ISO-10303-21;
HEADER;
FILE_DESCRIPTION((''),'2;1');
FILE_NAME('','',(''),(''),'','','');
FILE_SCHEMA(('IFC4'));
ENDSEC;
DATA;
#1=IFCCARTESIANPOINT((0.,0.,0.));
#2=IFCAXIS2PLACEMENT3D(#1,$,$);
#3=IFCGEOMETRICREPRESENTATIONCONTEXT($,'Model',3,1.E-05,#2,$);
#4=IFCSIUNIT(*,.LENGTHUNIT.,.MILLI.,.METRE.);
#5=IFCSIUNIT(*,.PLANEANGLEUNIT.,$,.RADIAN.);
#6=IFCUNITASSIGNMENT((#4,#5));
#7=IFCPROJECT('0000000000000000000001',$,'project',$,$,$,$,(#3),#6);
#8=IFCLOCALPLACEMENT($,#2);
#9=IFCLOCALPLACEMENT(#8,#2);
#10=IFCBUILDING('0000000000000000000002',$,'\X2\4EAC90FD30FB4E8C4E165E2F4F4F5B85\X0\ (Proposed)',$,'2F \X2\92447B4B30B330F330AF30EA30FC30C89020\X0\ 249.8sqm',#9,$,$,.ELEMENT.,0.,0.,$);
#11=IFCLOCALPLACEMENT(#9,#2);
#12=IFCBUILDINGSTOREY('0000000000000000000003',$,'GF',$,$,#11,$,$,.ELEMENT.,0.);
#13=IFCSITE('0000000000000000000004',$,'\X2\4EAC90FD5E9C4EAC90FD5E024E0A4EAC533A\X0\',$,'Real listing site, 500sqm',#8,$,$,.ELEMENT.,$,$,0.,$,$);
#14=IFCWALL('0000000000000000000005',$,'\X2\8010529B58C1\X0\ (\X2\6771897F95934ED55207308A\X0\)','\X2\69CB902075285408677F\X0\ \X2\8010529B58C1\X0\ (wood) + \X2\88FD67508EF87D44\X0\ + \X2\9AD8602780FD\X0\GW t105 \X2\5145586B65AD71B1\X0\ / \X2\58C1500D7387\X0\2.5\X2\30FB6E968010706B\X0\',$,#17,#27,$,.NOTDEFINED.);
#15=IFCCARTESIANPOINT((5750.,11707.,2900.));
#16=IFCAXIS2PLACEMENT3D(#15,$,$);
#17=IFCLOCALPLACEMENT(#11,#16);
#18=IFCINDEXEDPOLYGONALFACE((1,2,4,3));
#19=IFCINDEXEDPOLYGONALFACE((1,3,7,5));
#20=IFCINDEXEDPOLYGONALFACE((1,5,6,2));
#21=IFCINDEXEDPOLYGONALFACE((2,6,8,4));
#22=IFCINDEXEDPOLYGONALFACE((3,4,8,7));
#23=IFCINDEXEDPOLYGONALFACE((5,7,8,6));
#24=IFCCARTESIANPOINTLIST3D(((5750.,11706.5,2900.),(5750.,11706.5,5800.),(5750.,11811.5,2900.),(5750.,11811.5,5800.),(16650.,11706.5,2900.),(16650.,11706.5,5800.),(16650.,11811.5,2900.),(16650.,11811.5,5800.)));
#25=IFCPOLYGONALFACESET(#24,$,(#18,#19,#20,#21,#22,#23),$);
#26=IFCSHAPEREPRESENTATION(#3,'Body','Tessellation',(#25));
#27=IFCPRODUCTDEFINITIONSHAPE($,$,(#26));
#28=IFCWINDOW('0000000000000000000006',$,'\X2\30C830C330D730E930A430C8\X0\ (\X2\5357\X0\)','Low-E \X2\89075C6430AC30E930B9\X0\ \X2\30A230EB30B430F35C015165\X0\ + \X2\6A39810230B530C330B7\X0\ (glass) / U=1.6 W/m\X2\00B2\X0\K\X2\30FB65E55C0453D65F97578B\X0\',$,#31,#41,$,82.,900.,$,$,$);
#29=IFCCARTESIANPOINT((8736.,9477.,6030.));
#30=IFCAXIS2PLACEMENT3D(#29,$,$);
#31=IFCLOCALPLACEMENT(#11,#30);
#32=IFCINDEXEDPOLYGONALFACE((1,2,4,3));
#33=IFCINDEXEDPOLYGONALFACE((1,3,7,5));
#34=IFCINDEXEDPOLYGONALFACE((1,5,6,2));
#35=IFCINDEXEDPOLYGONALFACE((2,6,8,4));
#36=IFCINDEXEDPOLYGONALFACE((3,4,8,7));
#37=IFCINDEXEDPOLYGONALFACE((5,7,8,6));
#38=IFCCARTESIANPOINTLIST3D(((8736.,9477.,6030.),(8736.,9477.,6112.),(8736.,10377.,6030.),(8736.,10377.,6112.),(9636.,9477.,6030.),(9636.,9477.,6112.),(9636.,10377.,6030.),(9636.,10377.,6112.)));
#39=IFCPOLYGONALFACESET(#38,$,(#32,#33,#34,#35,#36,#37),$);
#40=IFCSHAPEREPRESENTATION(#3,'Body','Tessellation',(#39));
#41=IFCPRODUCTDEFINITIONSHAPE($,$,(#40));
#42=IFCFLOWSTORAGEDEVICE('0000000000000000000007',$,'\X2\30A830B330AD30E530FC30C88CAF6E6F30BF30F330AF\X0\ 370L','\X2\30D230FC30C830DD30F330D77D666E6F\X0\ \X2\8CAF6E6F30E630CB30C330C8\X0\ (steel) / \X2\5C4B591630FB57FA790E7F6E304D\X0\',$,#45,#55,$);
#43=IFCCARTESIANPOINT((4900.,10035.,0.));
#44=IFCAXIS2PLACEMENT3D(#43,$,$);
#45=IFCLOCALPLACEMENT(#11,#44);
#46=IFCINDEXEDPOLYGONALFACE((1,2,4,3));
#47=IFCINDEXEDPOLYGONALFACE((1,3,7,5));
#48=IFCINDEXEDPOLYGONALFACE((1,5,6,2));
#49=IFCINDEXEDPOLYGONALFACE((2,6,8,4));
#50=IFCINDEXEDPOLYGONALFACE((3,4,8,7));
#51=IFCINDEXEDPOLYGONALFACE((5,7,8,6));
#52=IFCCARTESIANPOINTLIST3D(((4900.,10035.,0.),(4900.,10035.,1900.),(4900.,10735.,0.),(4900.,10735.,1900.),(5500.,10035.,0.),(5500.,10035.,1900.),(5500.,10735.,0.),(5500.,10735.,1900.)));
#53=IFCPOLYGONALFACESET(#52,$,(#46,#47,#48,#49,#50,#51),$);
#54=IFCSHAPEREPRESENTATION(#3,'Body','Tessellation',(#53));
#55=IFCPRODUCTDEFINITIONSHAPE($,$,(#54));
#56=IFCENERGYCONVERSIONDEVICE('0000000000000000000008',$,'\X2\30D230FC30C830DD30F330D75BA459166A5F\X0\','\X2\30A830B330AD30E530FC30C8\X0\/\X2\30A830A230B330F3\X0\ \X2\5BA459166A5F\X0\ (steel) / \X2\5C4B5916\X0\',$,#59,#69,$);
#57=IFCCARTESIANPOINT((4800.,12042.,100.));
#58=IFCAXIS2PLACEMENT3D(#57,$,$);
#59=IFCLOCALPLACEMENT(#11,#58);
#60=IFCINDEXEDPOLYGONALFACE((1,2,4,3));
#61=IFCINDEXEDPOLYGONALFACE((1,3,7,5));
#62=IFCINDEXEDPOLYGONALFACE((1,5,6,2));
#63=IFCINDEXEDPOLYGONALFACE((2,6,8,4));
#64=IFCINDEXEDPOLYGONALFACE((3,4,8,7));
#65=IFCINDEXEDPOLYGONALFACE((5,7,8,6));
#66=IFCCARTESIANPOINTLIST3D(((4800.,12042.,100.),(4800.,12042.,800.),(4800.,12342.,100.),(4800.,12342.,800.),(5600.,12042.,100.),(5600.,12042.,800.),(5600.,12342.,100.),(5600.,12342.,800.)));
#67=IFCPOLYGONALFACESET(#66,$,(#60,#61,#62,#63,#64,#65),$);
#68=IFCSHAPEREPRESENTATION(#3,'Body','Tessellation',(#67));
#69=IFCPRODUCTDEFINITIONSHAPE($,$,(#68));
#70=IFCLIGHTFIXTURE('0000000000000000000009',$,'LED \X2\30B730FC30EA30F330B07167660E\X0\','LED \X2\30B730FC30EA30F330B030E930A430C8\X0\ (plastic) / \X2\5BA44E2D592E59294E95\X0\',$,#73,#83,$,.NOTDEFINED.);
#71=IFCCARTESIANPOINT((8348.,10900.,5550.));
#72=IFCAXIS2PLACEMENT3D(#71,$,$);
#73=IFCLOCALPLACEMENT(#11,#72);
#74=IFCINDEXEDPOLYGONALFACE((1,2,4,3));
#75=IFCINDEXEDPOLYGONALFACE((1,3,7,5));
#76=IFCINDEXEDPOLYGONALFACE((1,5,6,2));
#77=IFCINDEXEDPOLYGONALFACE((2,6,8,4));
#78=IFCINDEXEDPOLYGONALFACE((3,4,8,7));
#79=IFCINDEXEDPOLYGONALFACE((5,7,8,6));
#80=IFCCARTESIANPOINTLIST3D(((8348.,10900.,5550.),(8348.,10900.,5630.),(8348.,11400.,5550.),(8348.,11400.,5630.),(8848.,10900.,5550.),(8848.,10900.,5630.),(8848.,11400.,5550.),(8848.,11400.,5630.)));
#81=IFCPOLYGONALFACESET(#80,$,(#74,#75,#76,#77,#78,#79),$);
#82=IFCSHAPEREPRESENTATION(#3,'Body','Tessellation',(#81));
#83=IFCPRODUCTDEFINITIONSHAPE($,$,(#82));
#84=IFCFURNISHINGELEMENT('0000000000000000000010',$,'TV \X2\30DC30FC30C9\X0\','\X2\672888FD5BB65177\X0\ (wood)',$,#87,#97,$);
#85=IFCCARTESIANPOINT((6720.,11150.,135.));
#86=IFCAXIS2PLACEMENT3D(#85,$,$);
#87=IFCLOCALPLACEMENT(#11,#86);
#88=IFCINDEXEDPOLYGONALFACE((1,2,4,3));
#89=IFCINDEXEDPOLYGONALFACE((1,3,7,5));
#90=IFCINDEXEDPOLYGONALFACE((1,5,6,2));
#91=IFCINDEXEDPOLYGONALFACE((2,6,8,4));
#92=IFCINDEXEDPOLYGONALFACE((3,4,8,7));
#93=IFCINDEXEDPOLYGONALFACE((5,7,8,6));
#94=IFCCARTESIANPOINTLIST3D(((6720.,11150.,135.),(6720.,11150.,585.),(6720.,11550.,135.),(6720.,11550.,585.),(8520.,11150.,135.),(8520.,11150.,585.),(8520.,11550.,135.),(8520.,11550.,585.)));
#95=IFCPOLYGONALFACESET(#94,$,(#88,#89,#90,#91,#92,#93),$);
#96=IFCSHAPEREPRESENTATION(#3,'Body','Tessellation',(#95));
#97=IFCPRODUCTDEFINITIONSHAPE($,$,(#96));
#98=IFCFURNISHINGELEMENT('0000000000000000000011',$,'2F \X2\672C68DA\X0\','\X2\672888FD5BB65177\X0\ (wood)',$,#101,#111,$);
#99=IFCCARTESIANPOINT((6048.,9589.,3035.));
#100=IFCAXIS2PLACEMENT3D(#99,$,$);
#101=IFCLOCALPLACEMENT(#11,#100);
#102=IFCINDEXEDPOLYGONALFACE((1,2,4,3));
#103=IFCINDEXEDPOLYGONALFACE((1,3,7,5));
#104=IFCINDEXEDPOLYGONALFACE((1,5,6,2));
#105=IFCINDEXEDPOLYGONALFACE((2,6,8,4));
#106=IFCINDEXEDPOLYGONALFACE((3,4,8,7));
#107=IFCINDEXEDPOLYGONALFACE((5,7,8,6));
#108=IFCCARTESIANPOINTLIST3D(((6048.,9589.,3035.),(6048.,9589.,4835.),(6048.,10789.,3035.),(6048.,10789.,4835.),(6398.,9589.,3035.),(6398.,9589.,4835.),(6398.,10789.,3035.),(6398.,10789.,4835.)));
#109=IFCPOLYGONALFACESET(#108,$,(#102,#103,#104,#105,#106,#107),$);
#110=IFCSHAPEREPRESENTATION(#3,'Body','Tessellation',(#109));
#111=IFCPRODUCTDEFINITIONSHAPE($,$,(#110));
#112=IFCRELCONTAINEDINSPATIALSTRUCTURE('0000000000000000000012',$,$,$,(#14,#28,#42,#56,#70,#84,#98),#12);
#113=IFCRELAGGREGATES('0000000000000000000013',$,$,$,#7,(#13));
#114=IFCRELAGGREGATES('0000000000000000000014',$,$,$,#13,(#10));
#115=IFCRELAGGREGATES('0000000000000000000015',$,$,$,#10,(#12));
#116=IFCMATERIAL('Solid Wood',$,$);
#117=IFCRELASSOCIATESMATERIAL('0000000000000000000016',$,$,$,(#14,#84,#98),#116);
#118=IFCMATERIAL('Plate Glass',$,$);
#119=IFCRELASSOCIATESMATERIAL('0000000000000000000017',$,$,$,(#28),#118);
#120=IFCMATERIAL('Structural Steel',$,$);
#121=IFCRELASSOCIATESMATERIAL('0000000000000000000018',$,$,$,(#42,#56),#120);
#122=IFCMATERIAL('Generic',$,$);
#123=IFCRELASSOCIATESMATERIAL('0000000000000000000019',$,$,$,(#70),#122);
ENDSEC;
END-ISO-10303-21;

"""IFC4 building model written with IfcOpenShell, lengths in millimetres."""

from ifc_helpers import new_model, si_unit, frame, frame_2d, origin, place, context, project, spatial, rectangle, extrude, material, element, save


model = new_model("IFC4")

# Units and contexts
model_context = context("Model", 3, precision=1e-05, world=origin())
ifc_project = project(units=[si_unit("LENGTHUNIT", "METRE", prefix="MILLI"), si_unit("PLANEANGLEUNIT", "RADIAN")], contexts=[model_context])

# Site, building, storey
site_placement = place(None, origin())
site = spatial("IfcSite", under=ifc_project, at=site_placement, Name="京都府京都市上京区", ObjectType="Real listing site, 500sqm", CompositionType="ELEMENT", RefElevation=0.0)
building_placement = place(site_placement, origin())
building = spatial("IfcBuilding", under=site, at=building_placement, Name="京都・二世帯住宅 (Proposed)", ObjectType="2F 鉄筋コンクリート造 249.8sqm", CompositionType="ELEMENT", ElevationOfRefHeight=0.0, ElevationOfTerrain=0.0)
storey_placement = place(building_placement, origin())
storey = spatial("IfcBuildingStorey", under=building, at=storey_placement, Name="GF", CompositionType="ELEMENT", Elevation=0.0)

# Shared definitions
ifc_material_1 = material(Name="Solid Wood")

# Wall
wall_1_placement = place(storey_placement, frame((5750.0, 11707.0, 2900.0)))
element("IfcWall", 1, at=wall_1_placement, inside=storey, material=ifc_material_1, Name="耐力壁 (東西間仕切り)", Description="構造用合板 耐力壁 (wood) + 製材軸組 + 高性能GW t105 充填断熱 / 壁倍率2.5・準耐火", PredefinedType="NOTDEFINED", context=model_context, shape_type="SweptSolid", body=[
    extrude(rectangle(XDim=10900.0, YDim=105.0, at=frame_2d((5450.0, 52.0))), frame((5750.0, 11707.0, 2900.0)), (0.0, 0.0, 1.0), 2900.0),
])

# Window
ifc_material_2 = material(Name="Plate Glass")
window_placement = place(storey_placement, frame((8736.0, 9477.0, 6030.0)))
element("IfcWindow", 2, at=window_placement, inside=storey, material=ifc_material_2, Name="トップライト (南)", Description="Low-E 複層ガラス アルゴン封入 + 樹脂サッシ (glass) / U=1.6 W/m²K・日射取得型", OverallHeight=82.0, OverallWidth=900.0, context=model_context, shape_type="SweptSolid", body=[
    extrude(rectangle(XDim=900.0, YDim=900.0, at=frame_2d((450.0, 450.0))), frame((8736.0, 9477.0, 6030.0)), (0.0, 0.0, 1.0), 82.0),
])

# Flow storage device
ifc_material_3 = material(Name="Structural Steel")
flow_storage_device_placement = place(storey_placement, frame((4900.0, 10035.0, 0.0)))
element("IfcFlowStorageDevice", 3, at=flow_storage_device_placement, inside=storey, material=ifc_material_3, Name="エコキュート貯湯タンク 370L", Description="ヒートポンプ給湯 貯湯ユニット (steel) / 屋外・基礎置き", context=model_context, shape_type="SweptSolid", body=[
    extrude(rectangle(XDim=600.0, YDim=700.0, at=frame_2d((300.0, 350.0))), frame((4900.0, 10035.0, 0.0)), (0.0, 0.0, 1.0), 1900.0),
])

# Energy conversion device
energy_conversion_device_placement = place(storey_placement, frame((4800.0, 12042.0, 100.0)))
element("IfcEnergyConversionDevice", 4, at=energy_conversion_device_placement, inside=storey, material=ifc_material_3, Name="ヒートポンプ室外機", Description="エコキュート/エアコン 室外機 (steel) / 屋外", context=model_context, shape_type="SweptSolid", body=[
    extrude(rectangle(XDim=800.0, YDim=300.0, at=frame_2d((400.0, 150.0))), frame((4800.0, 12042.0, 100.0)), (0.0, 0.0, 1.0), 700.0),
])

# Light fixture
ifc_material_4 = material(Name="Generic")
light_fixture_placement = place(storey_placement, frame((8348.0, 10900.0, 5550.0)))
element("IfcLightFixture", 5, at=light_fixture_placement, inside=storey, material=ifc_material_4, Name="LED シーリング照明", Description="LED シーリングライト (plastic) / 室中央天井", PredefinedType="NOTDEFINED", context=model_context, shape_type="SweptSolid", body=[
    extrude(rectangle(XDim=500.0, YDim=500.0, at=frame_2d((250.0, 250.0))), frame((8348.0, 10900.0, 5550.0)), (0.0, 0.0, 1.0), 80.0),
])

# Furnishing elements
furnishing_1_placement = place(storey_placement, frame((6720.0, 11150.0, 135.0)))
element("IfcFurnishingElement", 6, at=furnishing_1_placement, inside=storey, material=ifc_material_1, Name="TV ボード", Description="木製家具 (wood)", context=model_context, shape_type="SweptSolid", body=[
    extrude(rectangle(XDim=1800.0, YDim=400.0, at=frame_2d((900.0, 200.0))), frame((6720.0, 11150.0, 135.0)), (0.0, 0.0, 1.0), 450.0),
])
furnishing_2_placement = place(storey_placement, frame((6048.0, 9589.0, 3035.0)))
element("IfcFurnishingElement", 7, at=furnishing_2_placement, inside=storey, material=ifc_material_1, Name="2F 本棚", Description="木製家具 (wood)", context=model_context, shape_type="SweptSolid", body=[
    extrude(rectangle(XDim=350.0, YDim=1200.0, at=frame_2d((175.0, 600.0))), frame((6048.0, 9589.0, 3035.0)), (0.0, 0.0, 1.0), 1800.0),
])

save(model, "model.ifc")
